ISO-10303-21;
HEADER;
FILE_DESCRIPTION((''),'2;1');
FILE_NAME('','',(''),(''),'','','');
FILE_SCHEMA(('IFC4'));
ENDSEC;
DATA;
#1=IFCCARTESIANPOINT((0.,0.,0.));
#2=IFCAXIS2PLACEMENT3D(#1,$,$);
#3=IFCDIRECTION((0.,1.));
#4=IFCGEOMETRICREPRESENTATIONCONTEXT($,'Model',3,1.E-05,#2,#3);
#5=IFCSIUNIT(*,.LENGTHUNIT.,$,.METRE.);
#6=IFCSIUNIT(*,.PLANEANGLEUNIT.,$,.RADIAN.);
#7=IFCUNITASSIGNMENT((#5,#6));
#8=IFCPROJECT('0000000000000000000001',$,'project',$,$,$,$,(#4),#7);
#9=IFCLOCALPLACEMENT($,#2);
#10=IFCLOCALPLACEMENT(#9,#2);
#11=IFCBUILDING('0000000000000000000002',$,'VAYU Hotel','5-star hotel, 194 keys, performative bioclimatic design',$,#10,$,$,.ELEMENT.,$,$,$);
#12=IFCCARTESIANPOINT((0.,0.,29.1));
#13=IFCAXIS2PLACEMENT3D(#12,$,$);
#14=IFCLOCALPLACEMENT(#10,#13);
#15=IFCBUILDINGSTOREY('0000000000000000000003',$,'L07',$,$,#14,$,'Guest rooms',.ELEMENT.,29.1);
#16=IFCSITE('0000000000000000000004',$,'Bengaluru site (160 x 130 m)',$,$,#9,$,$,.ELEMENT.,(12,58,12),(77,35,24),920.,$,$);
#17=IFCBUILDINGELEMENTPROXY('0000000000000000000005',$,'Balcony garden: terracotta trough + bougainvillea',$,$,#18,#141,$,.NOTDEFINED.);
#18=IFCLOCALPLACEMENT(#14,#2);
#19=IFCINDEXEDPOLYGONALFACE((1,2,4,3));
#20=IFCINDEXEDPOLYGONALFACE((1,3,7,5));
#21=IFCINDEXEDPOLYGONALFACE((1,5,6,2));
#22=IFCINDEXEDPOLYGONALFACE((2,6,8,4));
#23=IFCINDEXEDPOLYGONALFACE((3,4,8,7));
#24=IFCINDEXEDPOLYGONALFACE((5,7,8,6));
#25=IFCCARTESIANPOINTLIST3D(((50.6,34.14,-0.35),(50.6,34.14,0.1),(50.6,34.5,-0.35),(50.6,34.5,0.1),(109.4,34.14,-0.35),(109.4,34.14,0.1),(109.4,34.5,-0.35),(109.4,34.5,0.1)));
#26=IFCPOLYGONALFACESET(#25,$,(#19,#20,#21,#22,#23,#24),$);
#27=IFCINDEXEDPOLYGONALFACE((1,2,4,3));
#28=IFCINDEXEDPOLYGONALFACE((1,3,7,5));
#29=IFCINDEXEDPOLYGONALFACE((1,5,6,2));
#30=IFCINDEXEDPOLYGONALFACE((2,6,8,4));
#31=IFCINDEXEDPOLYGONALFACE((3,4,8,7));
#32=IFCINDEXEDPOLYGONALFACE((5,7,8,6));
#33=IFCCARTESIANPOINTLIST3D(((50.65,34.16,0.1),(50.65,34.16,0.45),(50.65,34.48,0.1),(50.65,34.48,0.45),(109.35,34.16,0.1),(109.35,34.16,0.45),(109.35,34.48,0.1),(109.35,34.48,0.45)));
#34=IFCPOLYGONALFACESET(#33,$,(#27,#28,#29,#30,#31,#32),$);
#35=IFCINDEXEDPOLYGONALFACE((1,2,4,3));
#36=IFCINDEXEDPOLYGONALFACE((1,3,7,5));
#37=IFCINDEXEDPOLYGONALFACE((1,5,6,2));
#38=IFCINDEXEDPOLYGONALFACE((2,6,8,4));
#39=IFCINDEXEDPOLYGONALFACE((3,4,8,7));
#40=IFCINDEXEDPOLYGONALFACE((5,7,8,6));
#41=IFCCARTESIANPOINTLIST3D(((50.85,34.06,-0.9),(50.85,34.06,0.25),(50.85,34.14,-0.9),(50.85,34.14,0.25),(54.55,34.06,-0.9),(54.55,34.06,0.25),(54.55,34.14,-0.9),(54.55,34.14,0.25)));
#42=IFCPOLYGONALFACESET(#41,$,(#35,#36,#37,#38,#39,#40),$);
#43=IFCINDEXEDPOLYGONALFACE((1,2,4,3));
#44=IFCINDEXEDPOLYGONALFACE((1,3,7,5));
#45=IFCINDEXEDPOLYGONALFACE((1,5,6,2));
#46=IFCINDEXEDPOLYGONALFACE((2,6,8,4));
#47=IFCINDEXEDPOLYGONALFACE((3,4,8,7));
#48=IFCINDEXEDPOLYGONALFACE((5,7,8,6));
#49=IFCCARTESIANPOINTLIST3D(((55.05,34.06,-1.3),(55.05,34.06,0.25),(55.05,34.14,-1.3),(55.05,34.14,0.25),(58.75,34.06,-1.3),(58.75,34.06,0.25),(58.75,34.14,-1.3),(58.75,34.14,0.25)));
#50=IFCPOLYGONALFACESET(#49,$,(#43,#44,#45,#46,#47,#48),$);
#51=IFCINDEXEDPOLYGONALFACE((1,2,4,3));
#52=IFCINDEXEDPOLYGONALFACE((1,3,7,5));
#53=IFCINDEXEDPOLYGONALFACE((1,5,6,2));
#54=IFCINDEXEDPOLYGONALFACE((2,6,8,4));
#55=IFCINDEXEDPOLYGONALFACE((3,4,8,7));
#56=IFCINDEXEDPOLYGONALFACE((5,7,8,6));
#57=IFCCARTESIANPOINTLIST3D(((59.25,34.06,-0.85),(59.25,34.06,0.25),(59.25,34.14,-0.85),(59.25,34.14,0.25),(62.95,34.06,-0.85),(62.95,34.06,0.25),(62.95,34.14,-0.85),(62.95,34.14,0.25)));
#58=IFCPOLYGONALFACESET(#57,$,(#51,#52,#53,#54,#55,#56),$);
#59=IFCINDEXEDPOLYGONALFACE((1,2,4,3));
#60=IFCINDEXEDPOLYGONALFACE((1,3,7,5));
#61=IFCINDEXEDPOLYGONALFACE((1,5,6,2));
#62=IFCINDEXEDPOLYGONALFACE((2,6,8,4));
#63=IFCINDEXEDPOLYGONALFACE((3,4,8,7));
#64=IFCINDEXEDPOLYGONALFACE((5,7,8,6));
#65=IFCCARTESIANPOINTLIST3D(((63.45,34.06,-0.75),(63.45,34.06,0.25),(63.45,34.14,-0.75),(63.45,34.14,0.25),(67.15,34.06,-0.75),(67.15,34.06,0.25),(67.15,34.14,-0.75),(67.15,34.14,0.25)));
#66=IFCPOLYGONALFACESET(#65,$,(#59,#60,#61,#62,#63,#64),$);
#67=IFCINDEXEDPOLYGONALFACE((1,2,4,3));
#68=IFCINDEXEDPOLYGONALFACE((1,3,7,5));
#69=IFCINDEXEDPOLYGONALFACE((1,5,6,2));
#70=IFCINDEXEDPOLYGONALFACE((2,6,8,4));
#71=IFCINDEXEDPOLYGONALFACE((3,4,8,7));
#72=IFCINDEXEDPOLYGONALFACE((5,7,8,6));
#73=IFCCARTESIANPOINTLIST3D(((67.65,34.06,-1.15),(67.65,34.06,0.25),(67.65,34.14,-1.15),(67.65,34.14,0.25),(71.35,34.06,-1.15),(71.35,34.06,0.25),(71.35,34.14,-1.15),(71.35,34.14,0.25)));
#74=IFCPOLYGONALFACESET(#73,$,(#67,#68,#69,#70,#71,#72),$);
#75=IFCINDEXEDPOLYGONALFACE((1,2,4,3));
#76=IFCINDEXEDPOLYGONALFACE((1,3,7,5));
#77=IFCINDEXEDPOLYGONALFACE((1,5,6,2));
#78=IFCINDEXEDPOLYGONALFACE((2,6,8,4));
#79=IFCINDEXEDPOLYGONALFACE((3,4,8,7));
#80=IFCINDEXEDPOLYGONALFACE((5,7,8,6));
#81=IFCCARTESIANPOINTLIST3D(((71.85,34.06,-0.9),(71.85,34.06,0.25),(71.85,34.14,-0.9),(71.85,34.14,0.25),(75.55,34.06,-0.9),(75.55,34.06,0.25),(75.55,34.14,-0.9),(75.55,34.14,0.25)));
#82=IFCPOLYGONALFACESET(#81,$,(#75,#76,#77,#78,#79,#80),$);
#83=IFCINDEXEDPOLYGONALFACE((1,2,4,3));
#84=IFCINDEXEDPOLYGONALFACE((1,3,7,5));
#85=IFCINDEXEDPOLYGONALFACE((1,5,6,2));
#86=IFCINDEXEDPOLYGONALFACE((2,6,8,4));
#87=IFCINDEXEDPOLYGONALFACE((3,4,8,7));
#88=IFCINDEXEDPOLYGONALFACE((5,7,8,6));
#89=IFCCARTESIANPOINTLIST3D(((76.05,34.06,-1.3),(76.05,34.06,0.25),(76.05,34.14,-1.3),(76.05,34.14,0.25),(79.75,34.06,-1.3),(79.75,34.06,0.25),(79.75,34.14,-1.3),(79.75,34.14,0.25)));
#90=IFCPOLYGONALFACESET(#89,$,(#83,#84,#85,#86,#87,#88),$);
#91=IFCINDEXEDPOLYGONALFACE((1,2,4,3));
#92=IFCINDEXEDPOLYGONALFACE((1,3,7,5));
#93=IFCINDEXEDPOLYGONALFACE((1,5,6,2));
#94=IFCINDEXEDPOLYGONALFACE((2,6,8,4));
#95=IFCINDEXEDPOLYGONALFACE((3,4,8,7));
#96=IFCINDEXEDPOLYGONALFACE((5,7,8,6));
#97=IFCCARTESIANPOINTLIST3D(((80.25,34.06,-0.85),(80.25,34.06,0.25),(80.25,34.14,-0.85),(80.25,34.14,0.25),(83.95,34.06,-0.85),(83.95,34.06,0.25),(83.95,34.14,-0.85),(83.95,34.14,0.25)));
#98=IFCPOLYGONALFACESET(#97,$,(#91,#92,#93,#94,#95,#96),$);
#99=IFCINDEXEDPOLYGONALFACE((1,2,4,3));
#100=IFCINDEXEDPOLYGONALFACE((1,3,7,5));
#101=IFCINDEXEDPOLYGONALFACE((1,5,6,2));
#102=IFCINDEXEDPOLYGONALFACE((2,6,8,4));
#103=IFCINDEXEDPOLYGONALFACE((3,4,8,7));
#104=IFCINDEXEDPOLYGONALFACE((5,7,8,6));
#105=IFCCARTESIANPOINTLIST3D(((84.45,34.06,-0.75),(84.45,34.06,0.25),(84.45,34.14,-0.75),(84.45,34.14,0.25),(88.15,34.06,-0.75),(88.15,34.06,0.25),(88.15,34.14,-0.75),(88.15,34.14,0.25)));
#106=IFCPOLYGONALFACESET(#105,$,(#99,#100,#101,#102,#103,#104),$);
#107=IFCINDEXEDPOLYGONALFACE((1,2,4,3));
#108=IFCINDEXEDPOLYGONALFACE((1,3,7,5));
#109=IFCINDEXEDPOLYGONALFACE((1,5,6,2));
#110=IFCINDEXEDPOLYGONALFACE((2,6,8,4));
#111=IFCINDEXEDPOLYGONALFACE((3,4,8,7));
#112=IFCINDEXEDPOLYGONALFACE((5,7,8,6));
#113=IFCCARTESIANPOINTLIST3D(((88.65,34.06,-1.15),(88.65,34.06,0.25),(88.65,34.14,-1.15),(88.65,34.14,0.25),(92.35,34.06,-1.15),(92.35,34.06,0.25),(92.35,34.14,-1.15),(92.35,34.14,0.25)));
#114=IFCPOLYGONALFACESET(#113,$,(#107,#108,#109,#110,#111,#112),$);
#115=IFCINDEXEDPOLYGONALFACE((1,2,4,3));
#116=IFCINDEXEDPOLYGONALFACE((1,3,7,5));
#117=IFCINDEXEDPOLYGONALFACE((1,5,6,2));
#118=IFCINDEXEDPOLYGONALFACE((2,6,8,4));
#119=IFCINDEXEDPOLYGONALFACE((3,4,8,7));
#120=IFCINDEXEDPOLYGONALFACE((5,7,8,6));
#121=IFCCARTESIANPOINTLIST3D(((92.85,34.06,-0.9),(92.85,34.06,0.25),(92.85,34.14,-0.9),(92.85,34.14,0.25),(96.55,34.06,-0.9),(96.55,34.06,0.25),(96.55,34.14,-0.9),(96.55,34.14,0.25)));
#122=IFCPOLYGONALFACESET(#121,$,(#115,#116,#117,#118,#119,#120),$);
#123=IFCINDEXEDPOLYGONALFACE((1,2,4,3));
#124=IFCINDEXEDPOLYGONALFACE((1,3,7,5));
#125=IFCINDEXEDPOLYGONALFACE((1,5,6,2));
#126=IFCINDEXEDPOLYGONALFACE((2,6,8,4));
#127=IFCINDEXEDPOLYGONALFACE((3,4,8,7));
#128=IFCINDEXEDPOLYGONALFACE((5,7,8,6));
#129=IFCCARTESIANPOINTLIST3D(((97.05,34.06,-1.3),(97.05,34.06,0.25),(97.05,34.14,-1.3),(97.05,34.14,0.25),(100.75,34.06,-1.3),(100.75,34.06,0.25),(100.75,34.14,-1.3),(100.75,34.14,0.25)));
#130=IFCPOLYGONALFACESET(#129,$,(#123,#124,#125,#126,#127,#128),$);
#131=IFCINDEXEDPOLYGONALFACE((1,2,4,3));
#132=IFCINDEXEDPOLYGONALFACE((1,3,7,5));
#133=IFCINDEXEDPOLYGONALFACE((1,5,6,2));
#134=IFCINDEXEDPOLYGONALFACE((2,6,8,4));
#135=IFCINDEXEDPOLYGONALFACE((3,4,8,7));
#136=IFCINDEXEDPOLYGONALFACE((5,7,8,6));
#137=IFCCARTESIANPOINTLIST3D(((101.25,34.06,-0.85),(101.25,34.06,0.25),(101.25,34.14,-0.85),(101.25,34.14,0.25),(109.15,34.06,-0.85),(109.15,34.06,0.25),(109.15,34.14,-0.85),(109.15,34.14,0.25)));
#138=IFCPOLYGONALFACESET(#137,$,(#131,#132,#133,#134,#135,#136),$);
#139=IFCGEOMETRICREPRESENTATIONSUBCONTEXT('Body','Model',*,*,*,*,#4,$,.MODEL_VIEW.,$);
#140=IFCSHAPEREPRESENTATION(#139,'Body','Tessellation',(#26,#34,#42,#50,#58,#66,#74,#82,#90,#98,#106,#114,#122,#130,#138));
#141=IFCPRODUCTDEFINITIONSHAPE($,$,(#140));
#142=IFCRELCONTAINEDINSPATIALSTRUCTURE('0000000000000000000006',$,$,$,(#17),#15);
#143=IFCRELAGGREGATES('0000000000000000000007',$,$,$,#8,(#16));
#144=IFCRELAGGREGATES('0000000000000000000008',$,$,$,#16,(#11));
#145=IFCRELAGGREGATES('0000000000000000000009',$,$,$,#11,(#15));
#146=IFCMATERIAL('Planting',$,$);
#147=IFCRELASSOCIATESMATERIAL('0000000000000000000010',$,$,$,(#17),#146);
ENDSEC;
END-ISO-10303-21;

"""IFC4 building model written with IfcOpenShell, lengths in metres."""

from ifc_helpers import new_model, si_unit, direction, frame, origin, place, context, subcontext, project, spatial, polyline, outline, extrude, material, element, save


model = new_model("IFC4")

# Units and contexts
model_context = context("Model", 3, precision=1e-05, world=origin(), true_north=direction((0.0, 1.0)))
body_context = subcontext(model_context, "Body", "Model", "MODEL_VIEW")
ifc_project = project(units=[si_unit("LENGTHUNIT", "METRE"), si_unit("PLANEANGLEUNIT", "RADIAN")], contexts=[model_context])

# Site, building, storey
site_placement = place(None, origin())
site = spatial("IfcSite", under=ifc_project, at=site_placement, Name="Bengaluru site (160 x 130 m)", CompositionType="ELEMENT", RefLatitude=(12, 58, 12), RefLongitude=(77, 35, 24), RefElevation=920.0)
building_placement = place(site_placement, origin())
building = spatial("IfcBuilding", under=site, at=building_placement, Name="VAYU Hotel", Description="5-star hotel, 194 keys, performative bioclimatic design", CompositionType="ELEMENT")
storey_placement = place(building_placement, frame((0.0, 0.0, 29.1)))
storey = spatial("IfcBuildingStorey", under=building, at=storey_placement, Name="L07", LongName="Guest rooms", CompositionType="ELEMENT", Elevation=29.1)

# Building element proxy
ifc_material_1 = material(Name="Planting")
proxy_placement = place(storey_placement, origin())
element("IfcBuildingElementProxy", 1, at=proxy_placement, inside=storey, material=ifc_material_1, Name="Balcony garden: terracotta trough + bougainvillea", PredefinedType="NOTDEFINED", context=body_context, shape_type="SweptSolid", body=[
    extrude(outline(polyline([(50.6, 34.14), (109.4, 34.14), (109.4, 34.5), (50.6, 34.5), (50.6, 34.14)])), frame((0.0, 0.0, -0.35)), (0.0, 0.0, 1.0), 0.45),
    extrude(outline(polyline([(50.65, 34.16), (109.35, 34.16), (109.35, 34.48), (50.65, 34.48), (50.65, 34.16)])), frame((0.0, 0.0, 0.1)), (0.0, 0.0, 1.0), 0.35),
    extrude(outline(polyline([(50.85, 34.06), (54.55, 34.06), (54.55, 34.14), (50.85, 34.14), (50.85, 34.06)])), frame((0.0, 0.0, -0.9)), (0.0, 0.0, 1.0), 1.15),
    extrude(outline(polyline([(55.05, 34.06), (58.75, 34.06), (58.75, 34.14), (55.05, 34.14), (55.05, 34.06)])), frame((0.0, 0.0, -1.3)), (0.0, 0.0, 1.0), 1.55),
    extrude(outline(polyline([(59.25, 34.06), (62.95, 34.06), (62.95, 34.14), (59.25, 34.14), (59.25, 34.06)])), frame((0.0, 0.0, -0.85)), (0.0, 0.0, 1.0), 1.1),
    extrude(outline(polyline([(63.45, 34.06), (67.15, 34.06), (67.15, 34.14), (63.45, 34.14), (63.45, 34.06)])), frame((0.0, 0.0, -0.75)), (0.0, 0.0, 1.0), 1.0),
    extrude(outline(polyline([(67.65, 34.06), (71.35, 34.06), (71.35, 34.14), (67.65, 34.14), (67.65, 34.06)])), frame((0.0, 0.0, -1.15)), (0.0, 0.0, 1.0), 1.4),
    extrude(outline(polyline([(71.85, 34.06), (75.55, 34.06), (75.55, 34.14), (71.85, 34.14), (71.85, 34.06)])), frame((0.0, 0.0, -0.9)), (0.0, 0.0, 1.0), 1.15),
    extrude(outline(polyline([(76.05, 34.06), (79.75, 34.06), (79.75, 34.14), (76.05, 34.14), (76.05, 34.06)])), frame((0.0, 0.0, -1.3)), (0.0, 0.0, 1.0), 1.55),
    extrude(outline(polyline([(80.25, 34.06), (83.95, 34.06), (83.95, 34.14), (80.25, 34.14), (80.25, 34.06)])), frame((0.0, 0.0, -0.85)), (0.0, 0.0, 1.0), 1.1),
    extrude(outline(polyline([(84.45, 34.06), (88.15, 34.06), (88.15, 34.14), (84.45, 34.14), (84.45, 34.06)])), frame((0.0, 0.0, -0.75)), (0.0, 0.0, 1.0), 1.0),
    extrude(outline(polyline([(88.65, 34.06), (92.35, 34.06), (92.35, 34.14), (88.65, 34.14), (88.65, 34.06)])), frame((0.0, 0.0, -1.15)), (0.0, 0.0, 1.0), 1.4),
    extrude(outline(polyline([(92.85, 34.06), (96.55, 34.06), (96.55, 34.14), (92.85, 34.14), (92.85, 34.06)])), frame((0.0, 0.0, -0.9)), (0.0, 0.0, 1.0), 1.15),
    extrude(outline(polyline([(97.05, 34.06), (100.75, 34.06), (100.75, 34.14), (97.05, 34.14), (97.05, 34.06)])), frame((0.0, 0.0, -1.3)), (0.0, 0.0, 1.0), 1.55),
    extrude(outline(polyline([(101.25, 34.06), (109.15, 34.06), (109.15, 34.14), (101.25, 34.14), (101.25, 34.06)])), frame((0.0, 0.0, -0.85)), (0.0, 0.0, 1.0), 1.1),
])

save(model, "model.ifc")
